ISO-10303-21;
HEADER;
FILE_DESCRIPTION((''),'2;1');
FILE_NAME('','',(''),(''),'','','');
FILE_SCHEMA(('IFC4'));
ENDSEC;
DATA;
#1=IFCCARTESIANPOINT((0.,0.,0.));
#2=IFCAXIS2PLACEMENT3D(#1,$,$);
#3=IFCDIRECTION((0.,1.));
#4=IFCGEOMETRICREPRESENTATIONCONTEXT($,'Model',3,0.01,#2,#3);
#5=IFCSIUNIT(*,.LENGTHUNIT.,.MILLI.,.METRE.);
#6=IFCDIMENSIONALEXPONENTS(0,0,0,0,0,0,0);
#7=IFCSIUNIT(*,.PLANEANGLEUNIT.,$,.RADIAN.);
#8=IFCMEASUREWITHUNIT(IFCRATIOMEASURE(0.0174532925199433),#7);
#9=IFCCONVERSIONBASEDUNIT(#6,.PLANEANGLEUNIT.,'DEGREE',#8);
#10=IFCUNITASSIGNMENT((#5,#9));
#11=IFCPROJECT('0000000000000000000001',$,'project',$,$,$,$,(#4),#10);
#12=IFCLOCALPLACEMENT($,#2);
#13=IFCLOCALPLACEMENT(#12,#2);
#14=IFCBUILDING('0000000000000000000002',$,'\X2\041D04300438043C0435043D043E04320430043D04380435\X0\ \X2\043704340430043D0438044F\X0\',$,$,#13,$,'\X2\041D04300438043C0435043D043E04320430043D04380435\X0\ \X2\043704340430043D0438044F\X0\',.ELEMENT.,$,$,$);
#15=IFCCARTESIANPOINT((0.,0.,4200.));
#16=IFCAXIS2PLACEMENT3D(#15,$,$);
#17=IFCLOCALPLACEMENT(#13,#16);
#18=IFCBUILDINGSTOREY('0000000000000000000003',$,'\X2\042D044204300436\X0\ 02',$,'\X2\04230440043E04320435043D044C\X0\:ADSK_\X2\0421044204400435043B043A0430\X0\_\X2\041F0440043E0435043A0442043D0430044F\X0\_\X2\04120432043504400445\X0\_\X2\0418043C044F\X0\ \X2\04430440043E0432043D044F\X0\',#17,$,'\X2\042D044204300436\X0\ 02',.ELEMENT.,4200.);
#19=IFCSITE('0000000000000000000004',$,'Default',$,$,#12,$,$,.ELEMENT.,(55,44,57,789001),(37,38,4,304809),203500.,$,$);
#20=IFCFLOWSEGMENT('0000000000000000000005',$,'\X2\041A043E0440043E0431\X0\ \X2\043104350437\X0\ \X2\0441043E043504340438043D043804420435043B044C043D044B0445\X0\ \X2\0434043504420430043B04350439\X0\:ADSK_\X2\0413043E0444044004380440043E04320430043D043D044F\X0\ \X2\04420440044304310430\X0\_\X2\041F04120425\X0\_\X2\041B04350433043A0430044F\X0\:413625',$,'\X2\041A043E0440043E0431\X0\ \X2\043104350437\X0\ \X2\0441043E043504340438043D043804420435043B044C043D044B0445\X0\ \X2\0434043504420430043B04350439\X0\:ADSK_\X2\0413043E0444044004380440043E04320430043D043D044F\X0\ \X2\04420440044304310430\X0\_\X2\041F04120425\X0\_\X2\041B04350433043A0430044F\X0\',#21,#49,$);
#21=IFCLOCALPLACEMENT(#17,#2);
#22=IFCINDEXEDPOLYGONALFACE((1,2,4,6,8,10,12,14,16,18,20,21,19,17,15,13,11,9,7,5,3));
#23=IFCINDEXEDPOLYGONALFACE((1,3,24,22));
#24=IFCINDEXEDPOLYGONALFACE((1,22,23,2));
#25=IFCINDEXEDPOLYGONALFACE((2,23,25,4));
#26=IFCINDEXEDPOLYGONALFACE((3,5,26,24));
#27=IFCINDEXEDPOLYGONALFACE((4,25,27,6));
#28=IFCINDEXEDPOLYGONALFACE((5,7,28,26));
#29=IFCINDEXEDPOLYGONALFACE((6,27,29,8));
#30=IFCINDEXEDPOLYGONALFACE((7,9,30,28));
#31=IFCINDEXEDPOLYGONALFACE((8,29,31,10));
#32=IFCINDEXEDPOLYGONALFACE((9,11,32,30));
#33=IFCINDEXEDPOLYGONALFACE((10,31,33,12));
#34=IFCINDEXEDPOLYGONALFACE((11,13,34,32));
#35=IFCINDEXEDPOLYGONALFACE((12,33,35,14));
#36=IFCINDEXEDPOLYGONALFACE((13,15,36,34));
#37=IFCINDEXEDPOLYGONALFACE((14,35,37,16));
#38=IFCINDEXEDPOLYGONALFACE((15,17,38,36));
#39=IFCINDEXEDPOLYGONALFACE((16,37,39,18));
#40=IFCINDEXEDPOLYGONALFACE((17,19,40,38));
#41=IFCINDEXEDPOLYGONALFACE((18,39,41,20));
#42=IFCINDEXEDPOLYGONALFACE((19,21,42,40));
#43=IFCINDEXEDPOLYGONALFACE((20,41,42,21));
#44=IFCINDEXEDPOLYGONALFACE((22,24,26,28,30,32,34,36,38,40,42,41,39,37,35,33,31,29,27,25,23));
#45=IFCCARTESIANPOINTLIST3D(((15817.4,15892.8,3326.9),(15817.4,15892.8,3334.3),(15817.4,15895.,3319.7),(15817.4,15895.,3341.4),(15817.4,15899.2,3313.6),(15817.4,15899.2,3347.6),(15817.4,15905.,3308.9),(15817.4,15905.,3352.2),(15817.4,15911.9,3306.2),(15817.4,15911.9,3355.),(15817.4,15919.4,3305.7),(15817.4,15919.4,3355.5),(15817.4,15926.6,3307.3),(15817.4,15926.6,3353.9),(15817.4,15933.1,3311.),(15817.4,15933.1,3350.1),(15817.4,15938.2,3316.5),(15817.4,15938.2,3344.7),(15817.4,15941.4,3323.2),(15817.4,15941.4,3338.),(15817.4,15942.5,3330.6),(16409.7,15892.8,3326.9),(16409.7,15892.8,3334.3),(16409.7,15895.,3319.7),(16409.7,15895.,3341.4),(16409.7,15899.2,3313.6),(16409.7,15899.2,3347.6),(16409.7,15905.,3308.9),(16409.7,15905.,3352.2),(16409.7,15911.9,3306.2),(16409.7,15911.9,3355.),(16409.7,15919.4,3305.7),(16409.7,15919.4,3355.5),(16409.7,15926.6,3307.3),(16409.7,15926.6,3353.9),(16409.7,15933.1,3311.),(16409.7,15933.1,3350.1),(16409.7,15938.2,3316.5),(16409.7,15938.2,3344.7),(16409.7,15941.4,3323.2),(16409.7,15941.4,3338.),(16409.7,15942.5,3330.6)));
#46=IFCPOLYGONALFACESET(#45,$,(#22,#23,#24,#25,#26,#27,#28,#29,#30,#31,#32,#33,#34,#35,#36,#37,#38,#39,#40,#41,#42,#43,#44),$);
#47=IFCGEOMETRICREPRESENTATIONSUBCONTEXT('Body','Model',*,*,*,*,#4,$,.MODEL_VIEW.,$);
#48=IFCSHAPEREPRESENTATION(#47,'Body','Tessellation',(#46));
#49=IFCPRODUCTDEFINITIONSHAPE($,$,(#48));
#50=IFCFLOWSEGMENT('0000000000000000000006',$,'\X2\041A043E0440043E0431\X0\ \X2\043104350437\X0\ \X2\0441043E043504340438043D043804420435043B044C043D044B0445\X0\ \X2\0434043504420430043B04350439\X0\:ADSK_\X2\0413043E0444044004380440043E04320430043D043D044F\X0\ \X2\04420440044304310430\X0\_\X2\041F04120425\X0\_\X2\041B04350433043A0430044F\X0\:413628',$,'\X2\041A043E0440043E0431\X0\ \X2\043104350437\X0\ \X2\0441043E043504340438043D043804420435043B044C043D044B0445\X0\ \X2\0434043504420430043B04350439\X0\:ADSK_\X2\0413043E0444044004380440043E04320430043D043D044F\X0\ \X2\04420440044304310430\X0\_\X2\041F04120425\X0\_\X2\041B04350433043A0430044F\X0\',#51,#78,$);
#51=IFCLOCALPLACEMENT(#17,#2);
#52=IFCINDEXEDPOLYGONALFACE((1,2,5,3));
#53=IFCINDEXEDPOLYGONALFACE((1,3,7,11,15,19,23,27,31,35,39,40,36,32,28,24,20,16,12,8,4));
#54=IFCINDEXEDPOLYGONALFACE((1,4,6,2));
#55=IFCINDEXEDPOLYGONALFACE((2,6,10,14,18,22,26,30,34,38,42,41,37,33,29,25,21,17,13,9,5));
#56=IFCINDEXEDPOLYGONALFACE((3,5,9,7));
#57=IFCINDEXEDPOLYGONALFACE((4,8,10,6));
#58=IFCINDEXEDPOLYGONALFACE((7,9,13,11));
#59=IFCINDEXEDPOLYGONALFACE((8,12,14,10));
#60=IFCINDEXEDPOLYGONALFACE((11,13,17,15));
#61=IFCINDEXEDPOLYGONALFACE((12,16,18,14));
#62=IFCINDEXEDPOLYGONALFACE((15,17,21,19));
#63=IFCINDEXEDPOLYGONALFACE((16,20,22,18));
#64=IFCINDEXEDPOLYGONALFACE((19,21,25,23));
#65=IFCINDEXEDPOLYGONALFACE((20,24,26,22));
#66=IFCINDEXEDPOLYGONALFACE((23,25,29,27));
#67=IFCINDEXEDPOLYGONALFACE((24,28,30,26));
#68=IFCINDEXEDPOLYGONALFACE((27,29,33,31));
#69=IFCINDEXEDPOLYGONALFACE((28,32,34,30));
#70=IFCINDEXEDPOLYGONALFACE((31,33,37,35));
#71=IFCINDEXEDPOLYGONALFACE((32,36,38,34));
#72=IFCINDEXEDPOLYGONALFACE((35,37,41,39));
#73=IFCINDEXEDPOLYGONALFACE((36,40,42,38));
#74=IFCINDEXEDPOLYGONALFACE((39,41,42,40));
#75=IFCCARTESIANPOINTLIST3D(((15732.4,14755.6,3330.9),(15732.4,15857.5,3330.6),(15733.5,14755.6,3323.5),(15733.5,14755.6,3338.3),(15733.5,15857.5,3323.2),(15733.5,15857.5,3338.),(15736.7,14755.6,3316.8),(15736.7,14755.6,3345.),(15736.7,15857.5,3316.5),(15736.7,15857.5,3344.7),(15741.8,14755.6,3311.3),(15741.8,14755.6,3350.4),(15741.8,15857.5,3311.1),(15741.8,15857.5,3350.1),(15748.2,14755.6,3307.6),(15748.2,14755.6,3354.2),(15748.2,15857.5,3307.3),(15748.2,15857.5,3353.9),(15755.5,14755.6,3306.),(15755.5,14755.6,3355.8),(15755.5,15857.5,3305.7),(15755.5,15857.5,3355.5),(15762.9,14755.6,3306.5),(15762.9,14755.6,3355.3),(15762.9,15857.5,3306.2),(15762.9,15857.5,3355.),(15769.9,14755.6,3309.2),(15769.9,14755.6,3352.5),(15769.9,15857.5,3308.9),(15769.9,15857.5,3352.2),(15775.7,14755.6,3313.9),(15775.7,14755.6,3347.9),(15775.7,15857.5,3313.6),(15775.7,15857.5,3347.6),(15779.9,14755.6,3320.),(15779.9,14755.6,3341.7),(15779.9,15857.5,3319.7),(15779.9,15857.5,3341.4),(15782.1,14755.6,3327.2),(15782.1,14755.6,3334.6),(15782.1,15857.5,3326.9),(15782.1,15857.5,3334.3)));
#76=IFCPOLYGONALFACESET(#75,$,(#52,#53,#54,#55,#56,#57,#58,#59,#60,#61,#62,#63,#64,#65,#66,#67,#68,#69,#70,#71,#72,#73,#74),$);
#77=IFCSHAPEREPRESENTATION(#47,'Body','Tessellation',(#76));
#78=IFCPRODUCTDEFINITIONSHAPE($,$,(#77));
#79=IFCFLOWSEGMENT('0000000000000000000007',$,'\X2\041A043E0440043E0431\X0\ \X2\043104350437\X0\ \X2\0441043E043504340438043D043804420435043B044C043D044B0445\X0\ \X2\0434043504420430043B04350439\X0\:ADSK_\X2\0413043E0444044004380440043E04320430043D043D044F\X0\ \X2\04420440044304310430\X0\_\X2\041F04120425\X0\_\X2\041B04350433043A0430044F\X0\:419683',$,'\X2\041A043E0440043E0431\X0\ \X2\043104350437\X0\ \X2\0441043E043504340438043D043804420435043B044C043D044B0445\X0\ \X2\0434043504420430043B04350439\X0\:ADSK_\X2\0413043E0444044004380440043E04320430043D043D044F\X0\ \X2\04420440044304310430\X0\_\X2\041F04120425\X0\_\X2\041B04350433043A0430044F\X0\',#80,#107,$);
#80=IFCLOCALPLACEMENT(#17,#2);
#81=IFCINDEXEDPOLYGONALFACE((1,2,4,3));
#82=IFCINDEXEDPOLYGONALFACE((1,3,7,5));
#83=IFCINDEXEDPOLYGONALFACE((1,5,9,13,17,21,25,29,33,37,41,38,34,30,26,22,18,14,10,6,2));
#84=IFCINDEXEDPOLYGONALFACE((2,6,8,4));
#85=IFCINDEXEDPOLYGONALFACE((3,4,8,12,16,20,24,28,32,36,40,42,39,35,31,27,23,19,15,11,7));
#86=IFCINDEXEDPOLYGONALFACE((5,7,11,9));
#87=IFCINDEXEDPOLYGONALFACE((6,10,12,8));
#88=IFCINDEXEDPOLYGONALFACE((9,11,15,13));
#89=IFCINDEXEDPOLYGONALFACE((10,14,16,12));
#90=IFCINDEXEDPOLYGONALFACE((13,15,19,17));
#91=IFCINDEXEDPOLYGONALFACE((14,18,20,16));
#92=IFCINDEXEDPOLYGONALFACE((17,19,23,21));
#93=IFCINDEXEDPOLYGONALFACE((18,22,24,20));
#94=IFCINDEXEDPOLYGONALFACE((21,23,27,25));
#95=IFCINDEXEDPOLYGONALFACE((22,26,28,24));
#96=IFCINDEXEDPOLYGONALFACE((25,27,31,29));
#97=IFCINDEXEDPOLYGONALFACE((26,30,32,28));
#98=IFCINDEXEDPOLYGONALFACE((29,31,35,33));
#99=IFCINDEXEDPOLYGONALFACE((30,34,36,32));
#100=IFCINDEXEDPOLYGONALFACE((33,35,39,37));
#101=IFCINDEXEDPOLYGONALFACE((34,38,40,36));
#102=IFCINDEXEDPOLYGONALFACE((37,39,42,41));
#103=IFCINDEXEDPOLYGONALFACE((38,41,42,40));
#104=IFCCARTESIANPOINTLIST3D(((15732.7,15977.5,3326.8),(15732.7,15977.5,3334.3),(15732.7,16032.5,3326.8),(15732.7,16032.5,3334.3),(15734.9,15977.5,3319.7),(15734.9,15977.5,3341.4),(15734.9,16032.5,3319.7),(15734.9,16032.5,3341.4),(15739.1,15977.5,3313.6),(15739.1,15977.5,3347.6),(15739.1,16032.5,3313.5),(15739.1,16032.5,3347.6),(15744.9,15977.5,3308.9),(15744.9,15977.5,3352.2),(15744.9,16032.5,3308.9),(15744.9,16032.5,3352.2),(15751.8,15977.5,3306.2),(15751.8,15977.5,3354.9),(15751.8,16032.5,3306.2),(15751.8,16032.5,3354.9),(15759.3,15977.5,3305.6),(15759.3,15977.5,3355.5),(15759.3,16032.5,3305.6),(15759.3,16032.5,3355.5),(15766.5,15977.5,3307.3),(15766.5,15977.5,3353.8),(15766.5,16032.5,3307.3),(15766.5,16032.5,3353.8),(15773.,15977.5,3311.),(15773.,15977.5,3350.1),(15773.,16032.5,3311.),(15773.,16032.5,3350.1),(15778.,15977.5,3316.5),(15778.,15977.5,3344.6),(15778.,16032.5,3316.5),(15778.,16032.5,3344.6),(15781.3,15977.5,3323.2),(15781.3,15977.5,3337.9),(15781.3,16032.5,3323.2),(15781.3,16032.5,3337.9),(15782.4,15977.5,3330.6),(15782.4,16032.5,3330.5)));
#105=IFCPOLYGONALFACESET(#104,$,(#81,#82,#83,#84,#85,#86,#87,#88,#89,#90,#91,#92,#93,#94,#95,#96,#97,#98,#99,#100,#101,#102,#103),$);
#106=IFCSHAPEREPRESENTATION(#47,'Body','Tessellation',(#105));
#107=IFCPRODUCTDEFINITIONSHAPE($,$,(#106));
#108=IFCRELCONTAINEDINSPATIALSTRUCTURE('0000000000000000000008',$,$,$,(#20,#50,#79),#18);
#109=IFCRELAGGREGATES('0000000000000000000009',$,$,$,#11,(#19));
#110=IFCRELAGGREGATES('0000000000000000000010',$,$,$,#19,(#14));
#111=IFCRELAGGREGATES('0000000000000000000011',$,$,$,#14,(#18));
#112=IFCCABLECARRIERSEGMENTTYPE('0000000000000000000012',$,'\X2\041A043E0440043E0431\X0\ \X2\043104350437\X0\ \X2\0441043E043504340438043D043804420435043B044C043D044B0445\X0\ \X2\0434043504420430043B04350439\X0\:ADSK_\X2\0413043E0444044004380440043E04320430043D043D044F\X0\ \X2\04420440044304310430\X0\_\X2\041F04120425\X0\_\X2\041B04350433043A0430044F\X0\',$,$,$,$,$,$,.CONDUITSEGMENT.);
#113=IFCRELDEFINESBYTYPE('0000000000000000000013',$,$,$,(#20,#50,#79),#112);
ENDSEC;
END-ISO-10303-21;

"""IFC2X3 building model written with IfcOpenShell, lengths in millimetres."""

from ifc_helpers import new_model, entity, si_unit, converted_unit, direction, frame, frame_2d, origin, origin_2d_with_axis, place, context, subcontext, project, spatial, circle, extrude, type_object, element, save


model = new_model("IFC2X3")

# Units and contexts
model_context = context("Model", 3, precision=0.01, world=origin(), true_north=direction((0.0, 1.0)))
body_context = subcontext(model_context, "Body", "Model", "MODEL_VIEW")
ifc_project = project(units=[si_unit("LENGTHUNIT", "METRE", prefix="MILLI"), converted_unit("PLANEANGLEUNIT", "DEGREE", entity("IfcRatioMeasure", 0.0174532925199433), si_unit("PLANEANGLEUNIT", "RADIAN"), dimensions=[0, 0, 0, 0, 0, 0, 0])], contexts=[model_context])

# Site, building, storey
site_placement = place(None, frame((0.0, 0.0, 0.0)))
site = spatial("IfcSite", under=ifc_project, at=site_placement, Name="Default", CompositionType="ELEMENT", RefLatitude=(55, 44, 57, 789001), RefLongitude=(37, 38, 4, 304809), RefElevation=203500.0)
building_placement = place(site_placement, origin())
building = spatial("IfcBuilding", under=site, at=building_placement, Name="Наименование здания", LongName="Наименование здания", CompositionType="ELEMENT")
storey_placement = place(building_placement, frame((0.0, 0.0, 4200.0)))
storey = spatial("IfcBuildingStorey", under=building, at=storey_placement, Name="Этаж 02", ObjectType="Уровень:ADSK_Стрелка_Проектная_Вверх_Имя уровня", LongName="Этаж 02", CompositionType="ELEMENT", Elevation=4200.0)

# Flow segments
cable_carrier_segment_type = type_object("IfcCableCarrierSegmentType", Name="Короб без соединительных деталей:ADSK_Гофрировання труба_ПВХ_Легкая", PredefinedType="CONDUITSEGMENT")
flow_segment_1_placement = place(storey_placement, frame((15817.4, 15890.9, 3304.0)))
element("IfcFlowSegment", 1, at=flow_segment_1_placement, inside=storey, type_object=cable_carrier_segment_type, Name="Короб без соединительных деталей:ADSK_Гофрировання труба_ПВХ_Легкая:413625", ObjectType="Короб без соединительных деталей:ADSK_Гофрировання труба_ПВХ_Легкая", context=body_context, shape_type="SweptSolid", body=[
    extrude(circle(Radius=25.0, at=frame_2d((0.0, 0.0), x_axis=(1.0, 0.0))), frame((0.0, 26.6, 26.6), z_axis=(1.0, 0.0, 0.000013), x_axis=(0.0, 1.0, 0.0)), (0.0, 0.0, 1.0), 592.3),
])
flow_segment_2_placement = place(storey_placement, frame((15730.8, 14755.6, 3304.0)))
element("IfcFlowSegment", 2, at=flow_segment_2_placement, inside=storey, type_object=cable_carrier_segment_type, Name="Короб без соединительных деталей:ADSK_Гофрировання труба_ПВХ_Легкая:413628", ObjectType="Короб без соединительных деталей:ADSK_Гофрировання труба_ПВХ_Легкая", context=body_context, shape_type="SweptSolid", body=[
    extrude(circle(Radius=25.0, at=origin_2d_with_axis()), frame((26.6, 1101.9, 26.6), z_axis=(0.0, -1.0, 0.000269), x_axis=(-1.0, 0.0, 0.0)), (0.0, 0.0, 1.0), 1101.9),
])
flow_segment_3_placement = place(storey_placement, frame((15730.8, 15977.5, 3304.0)))
element("IfcFlowSegment", 3, at=flow_segment_3_placement, inside=storey, type_object=cable_carrier_segment_type, Name="Короб без соединительных деталей:ADSK_Гофрировання труба_ПВХ_Легкая:419683", ObjectType="Короб без соединительных деталей:ADSK_Гофрировання труба_ПВХ_Легкая", context=body_context, shape_type="SweptSolid", body=[
    extrude(circle(Radius=25.0, at=frame_2d((0.0, 0.0), x_axis=(1.0, 0.0))), frame((26.6, 0.0, 26.6), z_axis=(0.0, 1.0, -0.000269), x_axis=(1.0, 0.0, 0.0)), (0.0, 0.0, 1.0), 55.0),
])

save(model, "model.ifc")
